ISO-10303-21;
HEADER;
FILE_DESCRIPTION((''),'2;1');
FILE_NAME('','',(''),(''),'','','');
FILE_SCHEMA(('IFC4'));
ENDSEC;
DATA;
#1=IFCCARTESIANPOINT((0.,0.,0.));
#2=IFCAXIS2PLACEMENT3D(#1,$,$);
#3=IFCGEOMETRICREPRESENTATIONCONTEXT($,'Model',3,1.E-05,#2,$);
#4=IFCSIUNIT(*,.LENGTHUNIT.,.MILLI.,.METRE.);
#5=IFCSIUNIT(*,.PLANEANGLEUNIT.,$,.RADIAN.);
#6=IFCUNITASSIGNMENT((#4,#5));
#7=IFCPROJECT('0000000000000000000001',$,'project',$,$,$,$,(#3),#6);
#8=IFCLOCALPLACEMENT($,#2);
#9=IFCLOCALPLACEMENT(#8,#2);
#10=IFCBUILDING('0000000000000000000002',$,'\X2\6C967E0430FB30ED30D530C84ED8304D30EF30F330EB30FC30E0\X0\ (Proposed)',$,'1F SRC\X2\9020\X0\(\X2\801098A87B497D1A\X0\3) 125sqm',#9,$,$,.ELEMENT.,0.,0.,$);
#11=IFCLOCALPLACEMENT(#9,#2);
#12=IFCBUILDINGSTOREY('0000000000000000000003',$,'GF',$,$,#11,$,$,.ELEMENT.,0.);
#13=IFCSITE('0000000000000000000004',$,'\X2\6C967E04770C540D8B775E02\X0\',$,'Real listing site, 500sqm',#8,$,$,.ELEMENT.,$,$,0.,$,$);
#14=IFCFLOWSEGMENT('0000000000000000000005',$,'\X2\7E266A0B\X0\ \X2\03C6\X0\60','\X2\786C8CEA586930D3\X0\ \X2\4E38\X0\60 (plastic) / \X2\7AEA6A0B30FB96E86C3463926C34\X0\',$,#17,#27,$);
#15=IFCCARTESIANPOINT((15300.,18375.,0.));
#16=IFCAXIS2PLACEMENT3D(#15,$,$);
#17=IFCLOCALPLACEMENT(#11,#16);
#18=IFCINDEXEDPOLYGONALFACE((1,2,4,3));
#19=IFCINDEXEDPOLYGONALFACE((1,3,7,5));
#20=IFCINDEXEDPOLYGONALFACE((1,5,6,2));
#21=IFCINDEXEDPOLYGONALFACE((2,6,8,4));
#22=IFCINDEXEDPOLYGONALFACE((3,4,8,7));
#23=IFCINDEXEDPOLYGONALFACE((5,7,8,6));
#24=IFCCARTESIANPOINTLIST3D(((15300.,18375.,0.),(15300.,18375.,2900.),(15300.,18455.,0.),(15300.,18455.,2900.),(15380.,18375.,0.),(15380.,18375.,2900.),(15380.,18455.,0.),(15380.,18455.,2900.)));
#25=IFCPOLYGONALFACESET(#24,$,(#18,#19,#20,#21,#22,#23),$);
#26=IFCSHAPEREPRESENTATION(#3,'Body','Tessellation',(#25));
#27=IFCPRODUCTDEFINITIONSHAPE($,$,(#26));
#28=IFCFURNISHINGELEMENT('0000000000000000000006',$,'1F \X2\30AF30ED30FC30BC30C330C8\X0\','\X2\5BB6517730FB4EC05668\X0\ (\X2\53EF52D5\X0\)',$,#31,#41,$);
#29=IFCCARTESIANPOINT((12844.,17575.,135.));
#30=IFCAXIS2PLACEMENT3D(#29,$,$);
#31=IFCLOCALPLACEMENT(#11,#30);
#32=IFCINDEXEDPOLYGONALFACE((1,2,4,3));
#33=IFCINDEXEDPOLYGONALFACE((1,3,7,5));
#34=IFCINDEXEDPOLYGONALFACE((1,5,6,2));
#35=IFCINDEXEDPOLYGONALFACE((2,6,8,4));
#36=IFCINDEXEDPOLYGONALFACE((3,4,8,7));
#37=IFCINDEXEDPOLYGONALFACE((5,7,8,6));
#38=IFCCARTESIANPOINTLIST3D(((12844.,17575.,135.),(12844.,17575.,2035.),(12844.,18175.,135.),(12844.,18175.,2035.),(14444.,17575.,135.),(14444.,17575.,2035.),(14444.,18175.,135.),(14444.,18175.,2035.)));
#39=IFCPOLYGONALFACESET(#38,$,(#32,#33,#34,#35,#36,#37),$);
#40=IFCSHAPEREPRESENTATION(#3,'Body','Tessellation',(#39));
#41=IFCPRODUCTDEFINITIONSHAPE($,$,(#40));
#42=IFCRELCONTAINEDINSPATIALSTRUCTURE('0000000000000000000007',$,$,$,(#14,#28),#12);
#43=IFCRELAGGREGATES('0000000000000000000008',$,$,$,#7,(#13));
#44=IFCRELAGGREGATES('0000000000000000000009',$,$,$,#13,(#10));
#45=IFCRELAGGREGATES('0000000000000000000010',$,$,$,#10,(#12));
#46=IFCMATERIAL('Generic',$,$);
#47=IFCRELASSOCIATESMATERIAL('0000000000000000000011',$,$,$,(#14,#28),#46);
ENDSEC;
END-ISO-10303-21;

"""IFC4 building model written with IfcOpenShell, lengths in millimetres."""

from ifc_helpers import new_model, si_unit, frame, frame_2d, origin, place, context, project, spatial, rectangle, extrude, material, element, save


model = new_model("IFC4")

# Units and contexts
model_context = context("Model", 3, precision=1e-05, world=origin())
ifc_project = project(units=[si_unit("LENGTHUNIT", "METRE", prefix="MILLI"), si_unit("PLANEANGLEUNIT", "RADIAN")], contexts=[model_context])

# Site, building, storey
site_placement = place(None, origin())
site = spatial("IfcSite", under=ifc_project, at=site_placement, Name="沖縄県名護市", ObjectType="Real listing site, 500sqm", CompositionType="ELEMENT", RefElevation=0.0)
building_placement = place(site_placement, origin())
building = spatial("IfcBuilding", under=site, at=building_placement, Name="沖縄・ロフト付きワンルーム (Proposed)", ObjectType="1F SRC造(耐風等級3) 125sqm", CompositionType="ELEMENT", ElevationOfRefHeight=0.0, ElevationOfTerrain=0.0)
storey_placement = place(building_placement, origin())
storey = spatial("IfcBuildingStorey", under=building, at=storey_placement, Name="GF", CompositionType="ELEMENT", Elevation=0.0)

# Shared definitions
ifc_material_1 = material(Name="Generic")

# Flow segment
flow_segment_placement = place(storey_placement, frame((15300.0, 18375.0, 0.0)))
element("IfcFlowSegment", 1, at=flow_segment_placement, inside=storey, material=ifc_material_1, Name="縦樋 φ60", Description="硬質塩ビ 丸60 (plastic) / 竪樋・雨水排水", context=model_context, shape_type="SweptSolid", body=[
    extrude(rectangle(XDim=80.0, YDim=80.0, at=frame_2d((40.0, 40.0))), frame((15300.0, 18375.0, 0.0)), (0.0, 0.0, 1.0), 2900.0),
])

# Furnishing element
furnishing_placement = place(storey_placement, frame((12844.0, 17575.0, 135.0)))
element("IfcFurnishingElement", 2, at=furnishing_placement, inside=storey, material=ifc_material_1, Name="1F クローゼット", Description="家具・什器 (可動)", context=model_context, shape_type="SweptSolid", body=[
    extrude(rectangle(XDim=1600.0, YDim=600.0, at=frame_2d((800.0, 300.0))), frame((12844.0, 17575.0, 135.0)), (0.0, 0.0, 1.0), 1900.0),
])

save(model, "model.ifc")
